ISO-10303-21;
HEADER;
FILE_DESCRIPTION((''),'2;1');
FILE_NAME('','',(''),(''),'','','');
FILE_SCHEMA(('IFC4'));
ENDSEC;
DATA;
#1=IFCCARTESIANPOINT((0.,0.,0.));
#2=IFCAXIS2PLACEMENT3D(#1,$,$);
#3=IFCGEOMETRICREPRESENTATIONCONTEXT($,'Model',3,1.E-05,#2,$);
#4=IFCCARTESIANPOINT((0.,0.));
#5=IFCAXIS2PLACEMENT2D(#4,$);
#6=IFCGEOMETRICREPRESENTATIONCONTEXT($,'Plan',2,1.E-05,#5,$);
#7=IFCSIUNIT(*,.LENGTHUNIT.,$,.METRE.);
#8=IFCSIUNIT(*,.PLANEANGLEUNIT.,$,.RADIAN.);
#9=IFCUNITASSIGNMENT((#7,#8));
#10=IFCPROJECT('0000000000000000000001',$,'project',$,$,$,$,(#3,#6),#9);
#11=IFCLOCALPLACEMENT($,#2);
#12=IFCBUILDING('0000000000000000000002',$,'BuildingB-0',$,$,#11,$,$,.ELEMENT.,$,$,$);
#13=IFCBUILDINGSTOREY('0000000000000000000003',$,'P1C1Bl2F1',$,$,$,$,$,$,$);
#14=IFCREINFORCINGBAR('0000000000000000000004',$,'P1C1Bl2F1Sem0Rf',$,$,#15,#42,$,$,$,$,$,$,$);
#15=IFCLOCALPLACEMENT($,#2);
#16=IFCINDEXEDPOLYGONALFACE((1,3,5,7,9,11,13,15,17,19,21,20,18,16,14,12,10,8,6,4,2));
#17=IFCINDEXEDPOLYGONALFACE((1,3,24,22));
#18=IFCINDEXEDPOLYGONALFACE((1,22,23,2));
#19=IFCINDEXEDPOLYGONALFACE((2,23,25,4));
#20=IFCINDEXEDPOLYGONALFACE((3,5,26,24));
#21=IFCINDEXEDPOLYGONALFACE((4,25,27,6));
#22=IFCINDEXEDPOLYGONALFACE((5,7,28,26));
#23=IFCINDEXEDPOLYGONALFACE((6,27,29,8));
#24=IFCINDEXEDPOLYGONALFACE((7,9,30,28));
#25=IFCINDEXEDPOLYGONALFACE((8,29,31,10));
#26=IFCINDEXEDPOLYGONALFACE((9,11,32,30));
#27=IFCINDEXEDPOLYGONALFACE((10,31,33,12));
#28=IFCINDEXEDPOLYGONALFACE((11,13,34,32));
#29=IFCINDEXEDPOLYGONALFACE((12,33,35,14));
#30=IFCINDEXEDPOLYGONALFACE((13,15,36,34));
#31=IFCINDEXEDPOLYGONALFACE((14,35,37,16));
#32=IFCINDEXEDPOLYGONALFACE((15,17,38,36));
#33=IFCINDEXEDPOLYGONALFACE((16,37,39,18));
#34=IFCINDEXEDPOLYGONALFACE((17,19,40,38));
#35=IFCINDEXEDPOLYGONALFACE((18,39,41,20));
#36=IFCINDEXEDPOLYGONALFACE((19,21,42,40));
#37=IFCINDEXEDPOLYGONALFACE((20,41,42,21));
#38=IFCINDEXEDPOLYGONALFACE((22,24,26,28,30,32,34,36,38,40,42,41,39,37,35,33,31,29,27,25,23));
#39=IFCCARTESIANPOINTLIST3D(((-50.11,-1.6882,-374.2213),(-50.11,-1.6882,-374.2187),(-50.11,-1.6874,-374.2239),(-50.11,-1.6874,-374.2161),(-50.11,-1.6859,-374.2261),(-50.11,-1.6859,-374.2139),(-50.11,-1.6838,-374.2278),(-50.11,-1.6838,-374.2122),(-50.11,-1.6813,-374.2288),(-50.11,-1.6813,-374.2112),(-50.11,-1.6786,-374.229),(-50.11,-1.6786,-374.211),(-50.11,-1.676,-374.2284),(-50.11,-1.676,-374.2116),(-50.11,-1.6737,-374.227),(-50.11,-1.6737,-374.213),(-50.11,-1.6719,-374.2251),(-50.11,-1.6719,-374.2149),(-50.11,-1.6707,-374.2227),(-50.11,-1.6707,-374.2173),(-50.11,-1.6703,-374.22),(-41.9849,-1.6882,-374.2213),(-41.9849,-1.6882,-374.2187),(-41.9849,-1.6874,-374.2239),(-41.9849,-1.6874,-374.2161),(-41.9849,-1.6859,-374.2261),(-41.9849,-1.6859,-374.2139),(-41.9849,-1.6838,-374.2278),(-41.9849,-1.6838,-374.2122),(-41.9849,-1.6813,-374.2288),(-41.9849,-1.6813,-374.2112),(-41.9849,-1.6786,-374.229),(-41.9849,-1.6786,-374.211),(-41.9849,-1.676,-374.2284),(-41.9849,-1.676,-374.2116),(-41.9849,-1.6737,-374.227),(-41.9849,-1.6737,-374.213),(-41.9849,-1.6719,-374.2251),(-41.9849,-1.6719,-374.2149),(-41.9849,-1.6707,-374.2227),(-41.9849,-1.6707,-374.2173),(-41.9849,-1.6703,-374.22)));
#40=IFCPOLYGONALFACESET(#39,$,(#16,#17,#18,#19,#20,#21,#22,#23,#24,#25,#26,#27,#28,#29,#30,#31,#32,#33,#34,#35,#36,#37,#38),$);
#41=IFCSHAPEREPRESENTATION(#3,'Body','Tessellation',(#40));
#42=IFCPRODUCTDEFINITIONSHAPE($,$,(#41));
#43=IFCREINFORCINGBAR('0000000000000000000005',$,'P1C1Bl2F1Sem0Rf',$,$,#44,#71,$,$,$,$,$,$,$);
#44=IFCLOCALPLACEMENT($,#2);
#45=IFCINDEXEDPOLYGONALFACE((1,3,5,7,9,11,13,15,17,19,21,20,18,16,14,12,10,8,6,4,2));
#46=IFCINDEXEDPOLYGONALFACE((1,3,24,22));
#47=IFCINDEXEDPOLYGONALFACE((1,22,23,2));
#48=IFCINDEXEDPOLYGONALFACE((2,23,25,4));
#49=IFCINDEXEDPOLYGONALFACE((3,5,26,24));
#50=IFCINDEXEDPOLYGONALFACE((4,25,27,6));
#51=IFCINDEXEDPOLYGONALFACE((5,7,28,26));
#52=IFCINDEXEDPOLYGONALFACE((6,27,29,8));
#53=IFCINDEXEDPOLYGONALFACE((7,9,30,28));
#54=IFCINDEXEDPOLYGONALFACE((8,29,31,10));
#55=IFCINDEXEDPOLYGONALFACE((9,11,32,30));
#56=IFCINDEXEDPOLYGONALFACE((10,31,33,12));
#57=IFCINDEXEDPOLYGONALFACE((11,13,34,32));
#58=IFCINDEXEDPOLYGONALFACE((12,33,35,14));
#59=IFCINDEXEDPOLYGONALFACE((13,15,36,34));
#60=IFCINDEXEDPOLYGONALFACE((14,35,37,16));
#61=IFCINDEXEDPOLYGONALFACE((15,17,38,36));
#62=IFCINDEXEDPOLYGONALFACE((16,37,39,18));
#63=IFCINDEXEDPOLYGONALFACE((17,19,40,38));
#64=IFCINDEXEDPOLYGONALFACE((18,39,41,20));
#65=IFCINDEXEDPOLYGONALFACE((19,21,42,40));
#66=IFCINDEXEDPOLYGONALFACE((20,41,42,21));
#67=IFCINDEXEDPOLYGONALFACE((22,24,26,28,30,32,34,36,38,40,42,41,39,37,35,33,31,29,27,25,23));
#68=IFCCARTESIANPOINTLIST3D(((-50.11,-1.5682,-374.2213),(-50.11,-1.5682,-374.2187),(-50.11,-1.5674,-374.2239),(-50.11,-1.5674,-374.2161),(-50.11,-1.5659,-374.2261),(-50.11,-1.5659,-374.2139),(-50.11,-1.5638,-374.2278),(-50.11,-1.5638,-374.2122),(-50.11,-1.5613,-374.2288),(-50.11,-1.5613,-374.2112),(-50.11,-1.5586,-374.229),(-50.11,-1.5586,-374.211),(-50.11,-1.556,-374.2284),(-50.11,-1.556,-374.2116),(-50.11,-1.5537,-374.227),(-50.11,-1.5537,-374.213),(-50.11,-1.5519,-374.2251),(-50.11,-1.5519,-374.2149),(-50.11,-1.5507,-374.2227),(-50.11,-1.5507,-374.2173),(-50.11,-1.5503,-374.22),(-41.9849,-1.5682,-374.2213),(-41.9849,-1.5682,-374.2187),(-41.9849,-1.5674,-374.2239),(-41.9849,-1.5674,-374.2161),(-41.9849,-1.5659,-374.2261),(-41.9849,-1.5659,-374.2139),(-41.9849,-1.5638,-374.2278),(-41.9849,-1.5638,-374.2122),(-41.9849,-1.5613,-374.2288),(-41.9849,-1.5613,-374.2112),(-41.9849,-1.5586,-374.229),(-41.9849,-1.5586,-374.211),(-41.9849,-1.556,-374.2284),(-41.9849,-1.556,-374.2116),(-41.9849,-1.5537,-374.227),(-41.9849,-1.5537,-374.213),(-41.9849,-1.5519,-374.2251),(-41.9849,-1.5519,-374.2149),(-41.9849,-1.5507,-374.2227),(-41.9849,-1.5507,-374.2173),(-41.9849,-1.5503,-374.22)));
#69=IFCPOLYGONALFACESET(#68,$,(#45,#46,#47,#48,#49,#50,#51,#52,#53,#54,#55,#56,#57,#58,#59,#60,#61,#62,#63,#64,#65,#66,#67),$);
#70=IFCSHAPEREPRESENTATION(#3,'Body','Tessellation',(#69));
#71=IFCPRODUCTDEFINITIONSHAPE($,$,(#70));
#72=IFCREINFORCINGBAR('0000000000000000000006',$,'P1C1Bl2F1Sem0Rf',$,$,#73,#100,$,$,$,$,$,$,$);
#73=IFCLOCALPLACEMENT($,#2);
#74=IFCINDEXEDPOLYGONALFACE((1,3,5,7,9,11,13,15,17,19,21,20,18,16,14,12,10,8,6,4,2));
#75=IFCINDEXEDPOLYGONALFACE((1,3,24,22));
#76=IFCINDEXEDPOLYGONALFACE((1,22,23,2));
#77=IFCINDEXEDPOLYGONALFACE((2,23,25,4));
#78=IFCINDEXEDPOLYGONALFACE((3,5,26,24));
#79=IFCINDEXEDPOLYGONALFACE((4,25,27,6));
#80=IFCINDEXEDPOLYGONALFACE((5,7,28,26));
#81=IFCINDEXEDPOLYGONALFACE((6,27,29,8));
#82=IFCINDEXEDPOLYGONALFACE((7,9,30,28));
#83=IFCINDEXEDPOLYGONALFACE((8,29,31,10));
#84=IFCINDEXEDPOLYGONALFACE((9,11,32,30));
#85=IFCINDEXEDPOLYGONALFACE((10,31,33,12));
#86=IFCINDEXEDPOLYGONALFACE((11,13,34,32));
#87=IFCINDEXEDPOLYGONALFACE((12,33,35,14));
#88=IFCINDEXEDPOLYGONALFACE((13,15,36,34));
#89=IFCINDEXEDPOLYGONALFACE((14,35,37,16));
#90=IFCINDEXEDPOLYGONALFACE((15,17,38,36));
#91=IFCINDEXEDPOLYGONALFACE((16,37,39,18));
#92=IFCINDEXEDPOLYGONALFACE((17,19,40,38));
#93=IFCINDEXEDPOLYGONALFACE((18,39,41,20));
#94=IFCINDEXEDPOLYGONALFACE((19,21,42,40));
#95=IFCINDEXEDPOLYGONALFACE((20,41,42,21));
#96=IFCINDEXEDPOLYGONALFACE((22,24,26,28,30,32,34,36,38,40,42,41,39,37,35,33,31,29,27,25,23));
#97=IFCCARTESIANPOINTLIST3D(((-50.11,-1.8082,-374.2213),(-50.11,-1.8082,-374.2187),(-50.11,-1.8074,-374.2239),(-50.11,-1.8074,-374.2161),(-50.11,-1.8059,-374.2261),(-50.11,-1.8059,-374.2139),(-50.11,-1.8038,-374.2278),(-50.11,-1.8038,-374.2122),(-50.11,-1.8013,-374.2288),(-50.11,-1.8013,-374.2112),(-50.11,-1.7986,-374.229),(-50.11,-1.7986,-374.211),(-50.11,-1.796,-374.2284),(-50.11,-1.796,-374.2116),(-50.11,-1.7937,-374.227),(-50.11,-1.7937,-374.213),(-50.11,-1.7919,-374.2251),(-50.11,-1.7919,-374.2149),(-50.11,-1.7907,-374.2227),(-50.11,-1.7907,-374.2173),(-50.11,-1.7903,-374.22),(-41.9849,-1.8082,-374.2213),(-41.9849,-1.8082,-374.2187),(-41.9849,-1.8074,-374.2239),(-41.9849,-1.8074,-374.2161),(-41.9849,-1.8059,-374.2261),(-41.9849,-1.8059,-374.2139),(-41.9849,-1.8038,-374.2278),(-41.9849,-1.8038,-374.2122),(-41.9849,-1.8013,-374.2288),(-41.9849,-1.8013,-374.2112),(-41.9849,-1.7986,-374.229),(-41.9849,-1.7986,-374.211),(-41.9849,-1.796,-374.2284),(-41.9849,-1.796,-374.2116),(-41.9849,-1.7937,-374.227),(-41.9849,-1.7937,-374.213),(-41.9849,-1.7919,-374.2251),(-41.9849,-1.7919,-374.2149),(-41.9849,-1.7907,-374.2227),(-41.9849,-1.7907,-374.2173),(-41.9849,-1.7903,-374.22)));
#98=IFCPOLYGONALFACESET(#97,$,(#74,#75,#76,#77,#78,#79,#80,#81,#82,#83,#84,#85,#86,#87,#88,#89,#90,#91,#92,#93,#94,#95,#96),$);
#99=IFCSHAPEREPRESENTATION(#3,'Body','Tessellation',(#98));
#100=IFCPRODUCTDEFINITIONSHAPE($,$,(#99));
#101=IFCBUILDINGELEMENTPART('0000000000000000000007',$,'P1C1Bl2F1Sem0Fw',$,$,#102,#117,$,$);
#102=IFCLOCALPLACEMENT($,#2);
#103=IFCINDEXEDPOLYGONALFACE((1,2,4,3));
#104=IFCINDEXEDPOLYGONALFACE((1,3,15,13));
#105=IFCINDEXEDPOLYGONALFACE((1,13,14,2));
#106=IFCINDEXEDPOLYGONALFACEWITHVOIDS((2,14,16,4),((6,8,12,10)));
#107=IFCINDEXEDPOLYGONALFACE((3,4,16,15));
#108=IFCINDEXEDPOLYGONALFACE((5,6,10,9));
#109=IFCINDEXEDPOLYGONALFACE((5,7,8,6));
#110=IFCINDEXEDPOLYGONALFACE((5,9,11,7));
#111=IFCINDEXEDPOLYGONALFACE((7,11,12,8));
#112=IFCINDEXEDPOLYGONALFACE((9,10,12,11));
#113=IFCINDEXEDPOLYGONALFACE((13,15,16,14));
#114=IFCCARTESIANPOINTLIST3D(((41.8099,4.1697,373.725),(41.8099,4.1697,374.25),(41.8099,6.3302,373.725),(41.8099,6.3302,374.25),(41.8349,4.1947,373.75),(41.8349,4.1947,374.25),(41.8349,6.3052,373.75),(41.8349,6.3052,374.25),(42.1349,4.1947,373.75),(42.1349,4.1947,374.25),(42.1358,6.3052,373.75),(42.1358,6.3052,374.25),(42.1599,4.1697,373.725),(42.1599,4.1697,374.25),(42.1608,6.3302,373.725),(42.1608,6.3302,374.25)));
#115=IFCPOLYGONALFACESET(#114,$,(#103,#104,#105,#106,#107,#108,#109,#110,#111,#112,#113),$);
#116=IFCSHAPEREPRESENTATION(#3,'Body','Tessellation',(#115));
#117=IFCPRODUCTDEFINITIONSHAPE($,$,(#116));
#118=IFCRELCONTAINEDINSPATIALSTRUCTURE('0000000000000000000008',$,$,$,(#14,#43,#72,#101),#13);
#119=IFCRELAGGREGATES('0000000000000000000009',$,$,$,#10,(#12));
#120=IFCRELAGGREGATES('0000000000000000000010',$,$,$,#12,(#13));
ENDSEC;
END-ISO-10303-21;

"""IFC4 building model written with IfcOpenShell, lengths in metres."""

from ifc_helpers import new_model, entity, si_unit, origin, origin_2d, place, context, project, spatial, polyline, outline, extrude, element, save


model = new_model("IFC4")

# Units and contexts
model_context = context("Model", 3, precision=1e-05, world=origin())
plan_context = context("Plan", 2, precision=1e-05, world=origin_2d())
ifc_project = project(units=[si_unit("LENGTHUNIT", "METRE"), si_unit("PLANEANGLEUNIT", "RADIAN")], contexts=[model_context, plan_context])

# Building, storey
building_placement = place(None, origin())
building = spatial("IfcBuilding", under=ifc_project, at=building_placement, Name="BuildingB-0", CompositionType="ELEMENT")
storey = spatial("IfcBuildingStorey", under=building, Name="P1C1Bl2F1")

# Reinforcing bars
element("IfcReinforcingBar", 1, inside=storey, Name="P1C1Bl2F1Sem0Rf", context=model_context, shape_type="SweptSolid", body=[
    entity("IfcSurfaceCurveSweptAreaSolid", entity("IfcCircleProfileDef", "AREA", None, None, 0.009), None, entity("IfcPolyline", [entity("IfcCartesianPoint", [41.9849, 1.6793, 374.22]), entity("IfcCartesianPoint", [50.11, 1.6793, 374.22])]), None, None, entity("IfcPlane", entity("IfcAxis2Placement3D", entity("IfcCartesianPoint", [41.9849, 1.6793, 374.22]), entity("IfcDirection", [0.0, 0.0, 1.0]), entity("IfcDirection", [1.0, 0.0, 0.0])))),
])
element("IfcReinforcingBar", 2, inside=storey, Name="P1C1Bl2F1Sem0Rf", context=model_context, shape_type="SweptSolid", body=[
    entity("IfcSurfaceCurveSweptAreaSolid", entity("IfcCircleProfileDef", "AREA", None, None, 0.009), None, entity("IfcPolyline", [entity("IfcCartesianPoint", [41.9849, 1.5593, 374.22]), entity("IfcCartesianPoint", [50.11, 1.5593, 374.22])]), None, None, entity("IfcPlane", entity("IfcAxis2Placement3D", entity("IfcCartesianPoint", [41.9849, 1.5593, 374.22]), entity("IfcDirection", [0.0, 0.0, 1.0]), entity("IfcDirection", [1.0, 0.0, 0.0])))),
])
element("IfcReinforcingBar", 3, inside=storey, Name="P1C1Bl2F1Sem0Rf", context=model_context, shape_type="SweptSolid", body=[
    entity("IfcSurfaceCurveSweptAreaSolid", entity("IfcCircleProfileDef", "AREA", None, None, 0.009), None, entity("IfcPolyline", [entity("IfcCartesianPoint", [41.9849, 1.7993, 374.22]), entity("IfcCartesianPoint", [50.11, 1.7993, 374.22])]), None, None, entity("IfcPlane", entity("IfcAxis2Placement3D", entity("IfcCartesianPoint", [41.9849, 1.7993, 374.22]), entity("IfcDirection", [0.0, 0.0, 1.0]), entity("IfcDirection", [1.0, 0.0, 0.0])))),
])

# Building element part, opening
building_element_part_1 = element("IfcBuildingElementPart", 4, inside=storey, Name="P1C1Bl2F1Sem0Fw", context=model_context, shape_type="SweptSolid", body=[
    extrude(outline(polyline([(41.8099, 4.1697, 373.725), (42.1599, 4.1697, 373.725), (42.1608, 6.3302, 373.725), (41.8099, 6.3302, 373.725), (41.8099, 4.1697, 373.725)])), None, (0.0, 0.0, 1.0), 0.525),
])
element("IfcOpeningElement", 5, inside=storey, cuts=building_element_part_1, context=model_context, shape_type="SweptSolid", body=[
    extrude(outline(polyline([(41.8349, 4.1947, 373.75), (42.1349, 4.1947, 373.75), (42.1358, 6.3052, 373.75), (41.8349, 6.3052, 373.75), (41.8349, 4.1947, 373.75)])), None, (0.0, 0.0, 1.0), 0.5),
])

save(model, "model.ifc")
